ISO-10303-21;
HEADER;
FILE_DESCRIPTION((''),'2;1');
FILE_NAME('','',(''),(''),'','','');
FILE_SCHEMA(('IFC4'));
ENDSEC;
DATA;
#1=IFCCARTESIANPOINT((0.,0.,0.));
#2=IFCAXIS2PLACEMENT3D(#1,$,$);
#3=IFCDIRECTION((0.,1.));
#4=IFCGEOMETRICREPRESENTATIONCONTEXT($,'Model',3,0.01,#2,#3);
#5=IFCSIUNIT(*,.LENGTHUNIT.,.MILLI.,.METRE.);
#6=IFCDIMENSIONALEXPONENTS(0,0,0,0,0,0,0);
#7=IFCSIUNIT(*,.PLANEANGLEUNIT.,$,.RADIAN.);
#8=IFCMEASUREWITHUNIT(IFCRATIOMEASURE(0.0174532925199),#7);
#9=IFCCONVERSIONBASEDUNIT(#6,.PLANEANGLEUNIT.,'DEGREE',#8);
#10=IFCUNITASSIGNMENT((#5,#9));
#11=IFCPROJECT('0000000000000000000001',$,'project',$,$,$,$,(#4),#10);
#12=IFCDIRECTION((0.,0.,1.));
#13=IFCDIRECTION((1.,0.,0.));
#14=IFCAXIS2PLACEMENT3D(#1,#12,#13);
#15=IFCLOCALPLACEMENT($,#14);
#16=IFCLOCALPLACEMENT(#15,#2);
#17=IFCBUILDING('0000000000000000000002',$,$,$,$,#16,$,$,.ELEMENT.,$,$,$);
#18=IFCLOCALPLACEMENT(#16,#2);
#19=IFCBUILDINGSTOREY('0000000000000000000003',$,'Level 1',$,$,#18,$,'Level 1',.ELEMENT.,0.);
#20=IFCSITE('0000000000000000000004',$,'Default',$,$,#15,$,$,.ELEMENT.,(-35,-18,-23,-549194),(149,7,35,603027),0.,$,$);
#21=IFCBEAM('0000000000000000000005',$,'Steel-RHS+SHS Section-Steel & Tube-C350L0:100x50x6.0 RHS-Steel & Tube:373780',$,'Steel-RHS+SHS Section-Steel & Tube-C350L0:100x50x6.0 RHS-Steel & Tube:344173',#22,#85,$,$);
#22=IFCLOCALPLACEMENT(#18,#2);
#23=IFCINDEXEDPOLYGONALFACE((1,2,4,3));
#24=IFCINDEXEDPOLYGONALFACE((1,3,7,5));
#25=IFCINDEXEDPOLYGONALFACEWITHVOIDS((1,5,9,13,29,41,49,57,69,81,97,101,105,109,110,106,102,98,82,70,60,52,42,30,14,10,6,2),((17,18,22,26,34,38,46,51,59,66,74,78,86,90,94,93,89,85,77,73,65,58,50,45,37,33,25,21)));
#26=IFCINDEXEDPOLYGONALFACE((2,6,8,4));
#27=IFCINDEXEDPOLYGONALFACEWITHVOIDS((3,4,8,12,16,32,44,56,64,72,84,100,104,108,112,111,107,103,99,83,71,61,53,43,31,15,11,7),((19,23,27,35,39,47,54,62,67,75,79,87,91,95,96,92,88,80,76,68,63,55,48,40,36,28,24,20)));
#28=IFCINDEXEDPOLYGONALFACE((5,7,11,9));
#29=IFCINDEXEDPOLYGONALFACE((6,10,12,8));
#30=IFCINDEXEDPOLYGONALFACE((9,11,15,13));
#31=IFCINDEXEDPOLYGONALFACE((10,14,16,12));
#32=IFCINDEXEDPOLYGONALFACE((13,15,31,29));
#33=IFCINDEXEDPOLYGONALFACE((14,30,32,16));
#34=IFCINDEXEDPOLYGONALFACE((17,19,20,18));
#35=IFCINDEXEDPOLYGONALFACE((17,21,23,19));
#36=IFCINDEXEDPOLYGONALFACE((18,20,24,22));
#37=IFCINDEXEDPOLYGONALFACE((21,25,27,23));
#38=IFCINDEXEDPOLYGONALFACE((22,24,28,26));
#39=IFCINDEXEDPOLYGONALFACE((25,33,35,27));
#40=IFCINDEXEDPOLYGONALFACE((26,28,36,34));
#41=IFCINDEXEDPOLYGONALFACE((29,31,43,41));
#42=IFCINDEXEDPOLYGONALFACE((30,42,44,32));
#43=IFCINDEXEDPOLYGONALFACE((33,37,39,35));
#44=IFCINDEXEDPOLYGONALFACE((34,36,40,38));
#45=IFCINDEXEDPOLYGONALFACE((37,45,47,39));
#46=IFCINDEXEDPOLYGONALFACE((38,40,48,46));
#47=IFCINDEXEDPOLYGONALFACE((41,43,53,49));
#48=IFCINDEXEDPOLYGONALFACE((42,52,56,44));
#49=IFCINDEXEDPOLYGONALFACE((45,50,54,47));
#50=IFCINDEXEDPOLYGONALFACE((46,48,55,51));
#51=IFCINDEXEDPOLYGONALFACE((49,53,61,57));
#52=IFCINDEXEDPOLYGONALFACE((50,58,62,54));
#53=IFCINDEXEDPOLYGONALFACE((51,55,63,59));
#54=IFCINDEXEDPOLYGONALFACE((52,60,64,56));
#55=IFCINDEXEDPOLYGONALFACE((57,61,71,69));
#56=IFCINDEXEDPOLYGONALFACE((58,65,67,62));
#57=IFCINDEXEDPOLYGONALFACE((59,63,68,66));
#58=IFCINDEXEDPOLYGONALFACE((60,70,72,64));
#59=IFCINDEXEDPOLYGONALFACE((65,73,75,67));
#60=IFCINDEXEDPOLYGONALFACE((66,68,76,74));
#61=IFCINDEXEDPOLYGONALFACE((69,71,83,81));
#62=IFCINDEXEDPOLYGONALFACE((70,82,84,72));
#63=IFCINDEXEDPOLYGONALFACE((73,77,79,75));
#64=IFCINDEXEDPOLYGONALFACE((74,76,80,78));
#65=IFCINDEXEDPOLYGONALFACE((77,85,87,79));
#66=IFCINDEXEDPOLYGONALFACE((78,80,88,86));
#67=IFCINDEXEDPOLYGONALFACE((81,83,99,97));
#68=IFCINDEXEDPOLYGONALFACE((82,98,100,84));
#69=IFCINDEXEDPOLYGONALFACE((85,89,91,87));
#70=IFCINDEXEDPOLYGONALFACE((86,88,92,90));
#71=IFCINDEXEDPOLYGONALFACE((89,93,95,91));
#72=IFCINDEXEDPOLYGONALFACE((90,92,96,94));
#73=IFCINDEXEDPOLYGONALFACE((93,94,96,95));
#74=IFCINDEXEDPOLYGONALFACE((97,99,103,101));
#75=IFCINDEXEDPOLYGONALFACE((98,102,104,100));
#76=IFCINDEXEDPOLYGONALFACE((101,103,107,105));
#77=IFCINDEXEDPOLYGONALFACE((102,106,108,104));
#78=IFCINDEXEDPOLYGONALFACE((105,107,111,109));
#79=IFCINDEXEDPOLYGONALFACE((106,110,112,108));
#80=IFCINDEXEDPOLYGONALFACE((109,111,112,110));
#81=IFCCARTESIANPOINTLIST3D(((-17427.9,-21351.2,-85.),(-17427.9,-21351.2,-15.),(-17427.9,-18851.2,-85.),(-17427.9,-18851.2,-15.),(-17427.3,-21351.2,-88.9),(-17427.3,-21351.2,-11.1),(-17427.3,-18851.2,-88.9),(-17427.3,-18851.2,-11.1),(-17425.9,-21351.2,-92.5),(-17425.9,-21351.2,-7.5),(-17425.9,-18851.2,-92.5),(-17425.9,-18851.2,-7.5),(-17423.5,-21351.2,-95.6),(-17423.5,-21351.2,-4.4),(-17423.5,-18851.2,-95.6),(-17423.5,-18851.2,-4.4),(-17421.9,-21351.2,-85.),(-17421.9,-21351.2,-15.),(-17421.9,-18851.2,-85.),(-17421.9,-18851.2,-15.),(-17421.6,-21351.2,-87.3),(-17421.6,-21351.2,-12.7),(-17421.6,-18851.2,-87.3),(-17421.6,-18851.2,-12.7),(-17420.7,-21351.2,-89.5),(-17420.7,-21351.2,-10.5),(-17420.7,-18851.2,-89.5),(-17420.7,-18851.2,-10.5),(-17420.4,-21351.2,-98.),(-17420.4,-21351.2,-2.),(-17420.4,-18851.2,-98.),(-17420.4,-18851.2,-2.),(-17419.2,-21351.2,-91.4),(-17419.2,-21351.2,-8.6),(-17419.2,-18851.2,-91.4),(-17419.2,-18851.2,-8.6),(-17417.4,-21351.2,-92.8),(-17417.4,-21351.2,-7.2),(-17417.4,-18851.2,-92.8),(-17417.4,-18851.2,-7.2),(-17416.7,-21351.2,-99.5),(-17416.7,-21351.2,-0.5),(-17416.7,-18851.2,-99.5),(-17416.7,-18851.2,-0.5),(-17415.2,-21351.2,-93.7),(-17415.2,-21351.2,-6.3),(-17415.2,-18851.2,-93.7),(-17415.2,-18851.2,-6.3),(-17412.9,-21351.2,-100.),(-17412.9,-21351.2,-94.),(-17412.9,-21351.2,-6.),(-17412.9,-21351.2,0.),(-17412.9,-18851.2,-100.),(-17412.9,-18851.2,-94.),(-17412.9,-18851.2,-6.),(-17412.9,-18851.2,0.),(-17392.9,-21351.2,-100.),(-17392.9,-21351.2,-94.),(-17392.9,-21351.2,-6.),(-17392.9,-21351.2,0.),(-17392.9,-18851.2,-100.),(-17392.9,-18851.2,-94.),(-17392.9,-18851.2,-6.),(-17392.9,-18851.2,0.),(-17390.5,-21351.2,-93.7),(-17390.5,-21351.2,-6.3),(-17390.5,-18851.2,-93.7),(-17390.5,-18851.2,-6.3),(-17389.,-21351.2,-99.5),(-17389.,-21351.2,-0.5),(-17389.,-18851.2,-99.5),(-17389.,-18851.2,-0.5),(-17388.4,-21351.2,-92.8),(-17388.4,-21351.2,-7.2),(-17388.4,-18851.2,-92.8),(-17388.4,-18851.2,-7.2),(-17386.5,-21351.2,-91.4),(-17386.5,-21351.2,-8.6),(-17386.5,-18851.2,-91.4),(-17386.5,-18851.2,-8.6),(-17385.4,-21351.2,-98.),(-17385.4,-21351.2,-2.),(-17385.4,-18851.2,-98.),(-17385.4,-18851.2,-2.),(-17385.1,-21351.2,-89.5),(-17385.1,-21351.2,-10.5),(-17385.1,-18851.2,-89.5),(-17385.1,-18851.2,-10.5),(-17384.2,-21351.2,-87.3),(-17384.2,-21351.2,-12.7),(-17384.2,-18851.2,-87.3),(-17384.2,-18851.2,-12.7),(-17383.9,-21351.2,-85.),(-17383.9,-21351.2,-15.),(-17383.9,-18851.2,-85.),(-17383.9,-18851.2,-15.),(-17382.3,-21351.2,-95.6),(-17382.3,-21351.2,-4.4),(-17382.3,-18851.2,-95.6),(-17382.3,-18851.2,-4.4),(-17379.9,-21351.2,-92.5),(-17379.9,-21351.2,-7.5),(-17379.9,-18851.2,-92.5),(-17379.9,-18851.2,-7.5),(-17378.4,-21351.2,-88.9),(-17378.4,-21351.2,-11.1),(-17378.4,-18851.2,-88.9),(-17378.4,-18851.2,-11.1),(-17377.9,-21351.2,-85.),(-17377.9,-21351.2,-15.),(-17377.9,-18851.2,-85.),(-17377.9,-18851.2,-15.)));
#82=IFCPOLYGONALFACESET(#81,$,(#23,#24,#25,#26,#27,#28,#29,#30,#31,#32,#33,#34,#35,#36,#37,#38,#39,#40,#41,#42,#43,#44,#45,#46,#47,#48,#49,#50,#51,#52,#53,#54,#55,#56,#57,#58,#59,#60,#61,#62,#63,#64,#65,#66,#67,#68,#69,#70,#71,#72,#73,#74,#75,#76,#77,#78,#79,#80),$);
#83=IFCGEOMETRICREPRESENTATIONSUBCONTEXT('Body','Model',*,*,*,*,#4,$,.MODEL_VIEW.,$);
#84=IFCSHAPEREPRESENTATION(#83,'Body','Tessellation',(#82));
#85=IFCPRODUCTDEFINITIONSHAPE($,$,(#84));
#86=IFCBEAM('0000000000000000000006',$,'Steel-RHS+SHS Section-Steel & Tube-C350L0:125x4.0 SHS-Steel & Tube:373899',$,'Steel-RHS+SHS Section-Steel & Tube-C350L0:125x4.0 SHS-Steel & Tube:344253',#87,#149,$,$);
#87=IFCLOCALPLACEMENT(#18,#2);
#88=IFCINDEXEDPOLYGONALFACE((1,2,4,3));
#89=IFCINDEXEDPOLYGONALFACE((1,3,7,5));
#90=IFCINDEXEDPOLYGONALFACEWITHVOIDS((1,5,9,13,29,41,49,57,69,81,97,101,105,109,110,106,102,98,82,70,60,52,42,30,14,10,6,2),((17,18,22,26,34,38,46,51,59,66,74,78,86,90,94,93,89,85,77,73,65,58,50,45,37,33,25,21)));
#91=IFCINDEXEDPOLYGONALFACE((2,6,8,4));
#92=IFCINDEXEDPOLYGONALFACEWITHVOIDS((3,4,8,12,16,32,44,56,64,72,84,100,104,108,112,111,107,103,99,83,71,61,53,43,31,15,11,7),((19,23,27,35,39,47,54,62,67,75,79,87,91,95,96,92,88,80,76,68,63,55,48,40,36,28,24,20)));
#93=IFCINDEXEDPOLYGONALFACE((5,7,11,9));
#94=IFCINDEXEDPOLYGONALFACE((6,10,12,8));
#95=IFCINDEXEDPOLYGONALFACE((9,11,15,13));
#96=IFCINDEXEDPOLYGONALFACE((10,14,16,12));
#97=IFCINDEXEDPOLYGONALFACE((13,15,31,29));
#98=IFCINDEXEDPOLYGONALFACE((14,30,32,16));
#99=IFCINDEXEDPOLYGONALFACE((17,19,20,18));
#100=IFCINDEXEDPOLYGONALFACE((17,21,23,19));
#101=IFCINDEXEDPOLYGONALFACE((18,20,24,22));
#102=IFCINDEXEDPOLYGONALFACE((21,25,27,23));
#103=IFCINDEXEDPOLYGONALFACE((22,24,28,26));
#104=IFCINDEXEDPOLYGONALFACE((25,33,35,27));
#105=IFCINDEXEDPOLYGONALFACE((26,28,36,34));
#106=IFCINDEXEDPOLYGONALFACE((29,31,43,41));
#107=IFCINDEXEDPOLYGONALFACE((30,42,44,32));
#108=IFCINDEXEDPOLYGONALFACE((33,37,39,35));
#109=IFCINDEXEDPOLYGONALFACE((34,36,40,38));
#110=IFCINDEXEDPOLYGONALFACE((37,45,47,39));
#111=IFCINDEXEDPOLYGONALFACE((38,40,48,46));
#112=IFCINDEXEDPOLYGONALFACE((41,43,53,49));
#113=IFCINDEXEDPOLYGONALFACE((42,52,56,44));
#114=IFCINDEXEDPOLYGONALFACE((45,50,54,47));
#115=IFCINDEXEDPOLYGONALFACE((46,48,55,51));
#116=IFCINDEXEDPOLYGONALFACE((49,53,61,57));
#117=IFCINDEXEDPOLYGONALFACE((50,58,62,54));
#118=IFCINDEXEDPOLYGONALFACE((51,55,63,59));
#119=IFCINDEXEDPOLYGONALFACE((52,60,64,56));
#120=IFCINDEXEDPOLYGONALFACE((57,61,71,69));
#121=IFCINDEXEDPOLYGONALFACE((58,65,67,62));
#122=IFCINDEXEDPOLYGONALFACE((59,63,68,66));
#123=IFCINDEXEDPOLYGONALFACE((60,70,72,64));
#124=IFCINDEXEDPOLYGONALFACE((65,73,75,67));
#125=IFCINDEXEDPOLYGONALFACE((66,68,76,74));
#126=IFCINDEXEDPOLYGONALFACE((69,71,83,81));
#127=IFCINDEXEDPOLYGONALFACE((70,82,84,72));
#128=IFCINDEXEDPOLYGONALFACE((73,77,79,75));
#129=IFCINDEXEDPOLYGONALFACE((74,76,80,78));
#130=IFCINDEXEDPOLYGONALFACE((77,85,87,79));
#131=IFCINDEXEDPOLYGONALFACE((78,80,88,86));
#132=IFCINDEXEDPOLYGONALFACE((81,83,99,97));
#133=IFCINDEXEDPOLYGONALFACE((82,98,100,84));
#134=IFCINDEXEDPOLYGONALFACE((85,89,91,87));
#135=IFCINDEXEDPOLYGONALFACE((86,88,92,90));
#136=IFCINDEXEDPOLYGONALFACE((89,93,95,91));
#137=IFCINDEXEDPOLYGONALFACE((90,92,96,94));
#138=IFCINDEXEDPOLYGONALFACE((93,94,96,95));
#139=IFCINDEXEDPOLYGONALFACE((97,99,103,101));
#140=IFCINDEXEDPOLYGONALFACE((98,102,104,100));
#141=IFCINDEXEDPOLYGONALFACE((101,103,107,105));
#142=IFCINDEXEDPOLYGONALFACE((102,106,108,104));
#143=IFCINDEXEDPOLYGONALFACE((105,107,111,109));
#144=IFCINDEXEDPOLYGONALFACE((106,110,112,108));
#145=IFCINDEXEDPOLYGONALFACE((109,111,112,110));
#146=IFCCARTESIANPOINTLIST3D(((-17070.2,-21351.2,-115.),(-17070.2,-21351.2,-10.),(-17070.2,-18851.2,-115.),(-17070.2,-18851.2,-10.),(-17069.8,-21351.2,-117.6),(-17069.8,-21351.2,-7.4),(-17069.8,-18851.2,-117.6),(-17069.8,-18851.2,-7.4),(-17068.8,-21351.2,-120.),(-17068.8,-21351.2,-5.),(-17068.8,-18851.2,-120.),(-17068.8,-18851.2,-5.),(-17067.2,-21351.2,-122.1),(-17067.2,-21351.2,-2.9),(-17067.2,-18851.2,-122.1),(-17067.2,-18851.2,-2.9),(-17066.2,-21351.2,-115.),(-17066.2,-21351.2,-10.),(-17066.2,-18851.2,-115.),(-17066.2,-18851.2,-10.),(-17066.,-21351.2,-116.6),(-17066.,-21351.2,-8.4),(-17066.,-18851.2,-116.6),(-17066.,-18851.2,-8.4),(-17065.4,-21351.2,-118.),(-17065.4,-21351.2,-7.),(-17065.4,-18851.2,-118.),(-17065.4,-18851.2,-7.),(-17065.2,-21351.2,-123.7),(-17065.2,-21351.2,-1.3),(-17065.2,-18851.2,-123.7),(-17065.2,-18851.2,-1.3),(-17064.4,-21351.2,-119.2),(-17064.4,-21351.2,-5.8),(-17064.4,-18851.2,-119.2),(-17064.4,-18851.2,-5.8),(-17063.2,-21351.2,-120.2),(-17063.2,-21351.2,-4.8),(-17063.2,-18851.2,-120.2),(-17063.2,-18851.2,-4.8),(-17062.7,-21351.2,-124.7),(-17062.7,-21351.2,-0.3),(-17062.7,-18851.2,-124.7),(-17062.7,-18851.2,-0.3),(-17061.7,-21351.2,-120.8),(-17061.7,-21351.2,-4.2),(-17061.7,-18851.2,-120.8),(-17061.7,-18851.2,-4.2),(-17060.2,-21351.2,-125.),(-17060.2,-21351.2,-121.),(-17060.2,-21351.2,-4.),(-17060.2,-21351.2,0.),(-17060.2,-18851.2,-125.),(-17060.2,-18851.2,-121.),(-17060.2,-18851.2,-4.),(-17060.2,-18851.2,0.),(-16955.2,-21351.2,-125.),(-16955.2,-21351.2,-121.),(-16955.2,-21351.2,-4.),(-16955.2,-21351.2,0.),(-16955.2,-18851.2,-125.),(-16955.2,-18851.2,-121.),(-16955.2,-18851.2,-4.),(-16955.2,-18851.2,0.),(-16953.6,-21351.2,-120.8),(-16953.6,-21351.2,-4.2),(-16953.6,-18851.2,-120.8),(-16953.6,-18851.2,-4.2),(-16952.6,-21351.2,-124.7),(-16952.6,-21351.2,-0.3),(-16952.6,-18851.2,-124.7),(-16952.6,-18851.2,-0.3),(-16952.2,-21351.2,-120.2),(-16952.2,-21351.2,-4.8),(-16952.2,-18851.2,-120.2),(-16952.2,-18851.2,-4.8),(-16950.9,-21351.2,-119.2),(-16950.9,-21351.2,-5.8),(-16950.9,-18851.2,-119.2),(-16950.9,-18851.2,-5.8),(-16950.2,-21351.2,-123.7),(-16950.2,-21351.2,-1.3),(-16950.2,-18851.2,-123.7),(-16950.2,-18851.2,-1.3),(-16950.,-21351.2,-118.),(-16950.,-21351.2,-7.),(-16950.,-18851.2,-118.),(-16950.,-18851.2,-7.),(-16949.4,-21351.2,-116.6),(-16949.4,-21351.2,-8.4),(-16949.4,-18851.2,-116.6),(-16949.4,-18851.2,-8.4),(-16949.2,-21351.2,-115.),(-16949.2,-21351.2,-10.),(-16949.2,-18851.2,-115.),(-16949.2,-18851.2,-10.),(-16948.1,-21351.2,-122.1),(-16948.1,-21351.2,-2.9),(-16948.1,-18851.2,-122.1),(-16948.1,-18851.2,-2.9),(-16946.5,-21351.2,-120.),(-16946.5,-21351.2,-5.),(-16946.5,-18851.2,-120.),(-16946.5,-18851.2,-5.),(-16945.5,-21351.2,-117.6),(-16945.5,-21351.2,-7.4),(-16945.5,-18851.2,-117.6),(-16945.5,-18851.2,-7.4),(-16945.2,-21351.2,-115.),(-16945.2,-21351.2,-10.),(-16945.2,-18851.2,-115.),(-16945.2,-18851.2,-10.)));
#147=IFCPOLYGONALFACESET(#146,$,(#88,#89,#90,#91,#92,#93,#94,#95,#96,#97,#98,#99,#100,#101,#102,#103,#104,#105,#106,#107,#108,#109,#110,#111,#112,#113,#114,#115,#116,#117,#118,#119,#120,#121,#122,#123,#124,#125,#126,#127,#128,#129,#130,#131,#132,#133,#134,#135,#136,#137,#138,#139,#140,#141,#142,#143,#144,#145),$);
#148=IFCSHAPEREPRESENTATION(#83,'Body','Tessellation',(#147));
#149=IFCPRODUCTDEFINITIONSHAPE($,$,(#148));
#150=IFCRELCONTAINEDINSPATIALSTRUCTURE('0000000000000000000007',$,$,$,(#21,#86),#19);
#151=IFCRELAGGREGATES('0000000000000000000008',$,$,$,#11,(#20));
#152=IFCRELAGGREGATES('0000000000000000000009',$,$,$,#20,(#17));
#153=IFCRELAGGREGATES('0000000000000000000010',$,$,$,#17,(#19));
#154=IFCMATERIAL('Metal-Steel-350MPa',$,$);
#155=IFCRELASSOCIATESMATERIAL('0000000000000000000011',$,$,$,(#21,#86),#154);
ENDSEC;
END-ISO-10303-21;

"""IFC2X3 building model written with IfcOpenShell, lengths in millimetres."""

from ifc_helpers import new_model, entity, si_unit, converted_unit, direction, frame, frame_2d, origin, origin_with_axes, place, context, subcontext, project, spatial, polyline, circle_curve, parameter, trimmed, segment, composite_curve, outline, extrude, material, element, save


model = new_model("IFC2X3")

# Units and contexts
model_context = context("Model", 3, precision=0.01, world=origin(), true_north=direction((0.0, 1.0)))
body_context = subcontext(model_context, "Body", "Model", "MODEL_VIEW")
ifc_project = project(units=[si_unit("LENGTHUNIT", "METRE", prefix="MILLI"), converted_unit("PLANEANGLEUNIT", "DEGREE", entity("IfcRatioMeasure", 0.0174532925199), si_unit("PLANEANGLEUNIT", "RADIAN"), dimensions=[0, 0, 0, 0, 0, 0, 0])], contexts=[model_context])

# Site, building, storey
site_placement = place(None, origin_with_axes())
site = spatial("IfcSite", under=ifc_project, at=site_placement, Name="Default", CompositionType="ELEMENT", RefLatitude=(-35, -18, -23, -549194), RefLongitude=(149, 7, 35, 603027), RefElevation=0.0)
building_placement = place(site_placement, origin())
building = spatial("IfcBuilding", under=site, at=building_placement, CompositionType="ELEMENT")
storey_placement = place(building_placement, origin())
storey = spatial("IfcBuildingStorey", under=building, at=storey_placement, Name="Level 1", LongName="Level 1", CompositionType="ELEMENT", Elevation=0.0)

# Beams
ifc_material = material(Name="Metal-Steel-350MPa")
beam_1_placement = place(storey_placement, frame((-17402.9, -18851.2, 0.0), z_axis=(0.0, 0.0, 1.0), x_axis=(0.0, -1.0, 0.0)))
element("IfcBeam", 1, at=beam_1_placement, inside=storey, material=ifc_material, Name="Steel-RHS+SHS Section-Steel & Tube-C350L0:100x50x6.0 RHS-Steel & Tube:373780", ObjectType="Steel-RHS+SHS Section-Steel & Tube-C350L0:100x50x6.0 RHS-Steel & Tube:344173", context=body_context, shape_type="SweptSolid", body=[
    extrude(outline(composite_curve([segment(trimmed(circle_curve(frame_2d((-10.0, -35.0), x_axis=(1.0, 0.0)), 15.0), [parameter(180.0)], [parameter(270.0)], True, "PARAMETER"), True, "CONTINUOUS"), segment(polyline([(-10.0, -50.0), (10.0, -50.0)]), True, "CONTINUOUS"), segment(trimmed(circle_curve(frame_2d((10.0, -35.0), x_axis=(1.0, 0.0)), 15.0), [parameter(270.0)], [parameter(0.0)], True, "PARAMETER"), True, "CONTINUOUS"), segment(polyline([(25.0, -35.0), (25.0, 35.0)]), True, "CONTINUOUS"), segment(trimmed(circle_curve(frame_2d((10.0, 35.0), x_axis=(1.0, 0.0)), 15.0), [parameter(0.0)], [parameter(90.0)], True, "PARAMETER"), True, "CONTINUOUS"), segment(polyline([(10.0, 50.0), (-10.0, 50.0)]), True, "CONTINUOUS"), segment(trimmed(circle_curve(frame_2d((-10.0, 35.0), x_axis=(1.0, 0.0)), 15.0), [parameter(90.0)], [parameter(180.0)], True, "PARAMETER"), True, "CONTINUOUS"), segment(polyline([(-25.0, 35.0), (-25.0, -35.0)]), True, "CONTINUOUS")], self_intersect=False), holes=[composite_curve([segment(polyline([(10.0, -44.0), (-10.0, -44.0)]), True, "CONTINUOUS"), segment(trimmed(circle_curve(frame_2d((-10.0, -35.0), x_axis=(1.0, 0.0)), 9.0), [parameter(180.0)], [parameter(270.0)], True, "PARAMETER"), False, "CONTINUOUS"), segment(polyline([(-19.0, -35.0), (-19.0, 35.0)]), True, "CONTINUOUS"), segment(trimmed(circle_curve(frame_2d((-10.0, 35.0), x_axis=(1.0, 0.0)), 9.0), [parameter(90.0)], [parameter(180.0)], True, "PARAMETER"), False, "CONTINUOUS"), segment(polyline([(-10.0, 44.0), (10.0, 44.0)]), True, "CONTINUOUS"), segment(trimmed(circle_curve(frame_2d((10.0, 35.0), x_axis=(1.0, 0.0)), 9.0), [parameter(360.0)], [parameter(90.0)], True, "PARAMETER"), False, "CONTINUOUS"), segment(polyline([(19.0, 35.0), (19.0, -35.0)]), True, "CONTINUOUS"), segment(trimmed(circle_curve(frame_2d((10.0, -35.0), x_axis=(1.0, 0.0)), 9.0), [parameter(270.0)], [parameter(360.0)], True, "PARAMETER"), False, "CONTINUOUS")], self_intersect=False)]), frame((0.0, 0.0, -50.0), z_axis=(1.0, 0.0, 0.0), x_axis=(0.0, -1.0, 0.0)), (0.0, 0.0, 1.0), 2500.0),
])
beam_2_placement = place(storey_placement, frame((-17007.7, -18851.2, 0.0), z_axis=(0.0, 0.0, 1.0), x_axis=(0.0, -1.0, 0.0)))
element("IfcBeam", 2, at=beam_2_placement, inside=storey, material=ifc_material, Name="Steel-RHS+SHS Section-Steel & Tube-C350L0:125x4.0 SHS-Steel & Tube:373899", ObjectType="Steel-RHS+SHS Section-Steel & Tube-C350L0:125x4.0 SHS-Steel & Tube:344253", context=body_context, shape_type="SweptSolid", body=[
    extrude(outline(composite_curve([segment(trimmed(circle_curve(frame_2d((-52.5, -52.5), x_axis=(1.0, 0.0)), 10.0), [parameter(180.0)], [parameter(270.0)], True, "PARAMETER"), True, "CONTINUOUS"), segment(polyline([(-52.5, -62.5), (52.5, -62.5)]), True, "CONTINUOUS"), segment(trimmed(circle_curve(frame_2d((52.5, -52.5), x_axis=(1.0, 0.0)), 10.0), [parameter(270.0)], [parameter(0.0)], True, "PARAMETER"), True, "CONTINUOUS"), segment(polyline([(62.5, -52.5), (62.5, 52.5)]), True, "CONTINUOUS"), segment(trimmed(circle_curve(frame_2d((52.5, 52.5), x_axis=(1.0, 0.0)), 10.0), [parameter(0.0)], [parameter(90.0)], True, "PARAMETER"), True, "CONTINUOUS"), segment(polyline([(52.5, 62.5), (-52.5, 62.5)]), True, "CONTINUOUS"), segment(trimmed(circle_curve(frame_2d((-52.5, 52.5), x_axis=(1.0, 0.0)), 10.0), [parameter(90.0)], [parameter(180.0)], True, "PARAMETER"), True, "CONTINUOUS"), segment(polyline([(-62.5, 52.5), (-62.5, -52.5)]), True, "CONTINUOUS")], self_intersect=False), holes=[composite_curve([segment(polyline([(52.5, -58.5), (-52.5, -58.5)]), True, "CONTINUOUS"), segment(trimmed(circle_curve(frame_2d((-52.5, -52.5), x_axis=(1.0, 0.0)), 6.0), [parameter(180.0)], [parameter(270.0)], True, "PARAMETER"), False, "CONTINUOUS"), segment(polyline([(-58.5, -52.5), (-58.5, 52.5)]), True, "CONTINUOUS"), segment(trimmed(circle_curve(frame_2d((-52.5, 52.5), x_axis=(1.0, 0.0)), 6.0), [parameter(90.0)], [parameter(180.0)], True, "PARAMETER"), False, "CONTINUOUS"), segment(polyline([(-52.5, 58.5), (52.5, 58.5)]), True, "CONTINUOUS"), segment(trimmed(circle_curve(frame_2d((52.5, 52.5), x_axis=(1.0, 0.0)), 6.0), [parameter(360.0)], [parameter(90.0)], True, "PARAMETER"), False, "CONTINUOUS"), segment(polyline([(58.5, 52.5), (58.5, -52.5)]), True, "CONTINUOUS"), segment(trimmed(circle_curve(frame_2d((52.5, -52.5), x_axis=(1.0, 0.0)), 6.0), [parameter(270.0)], [parameter(0.0)], True, "PARAMETER"), False, "CONTINUOUS")], self_intersect=False)]), frame((0.0, 0.0, -62.5), z_axis=(1.0, 0.0, 0.0), x_axis=(0.0, -1.0, 0.0)), (0.0, 0.0, 1.0), 2500.0),
])

save(model, "model.ifc")
